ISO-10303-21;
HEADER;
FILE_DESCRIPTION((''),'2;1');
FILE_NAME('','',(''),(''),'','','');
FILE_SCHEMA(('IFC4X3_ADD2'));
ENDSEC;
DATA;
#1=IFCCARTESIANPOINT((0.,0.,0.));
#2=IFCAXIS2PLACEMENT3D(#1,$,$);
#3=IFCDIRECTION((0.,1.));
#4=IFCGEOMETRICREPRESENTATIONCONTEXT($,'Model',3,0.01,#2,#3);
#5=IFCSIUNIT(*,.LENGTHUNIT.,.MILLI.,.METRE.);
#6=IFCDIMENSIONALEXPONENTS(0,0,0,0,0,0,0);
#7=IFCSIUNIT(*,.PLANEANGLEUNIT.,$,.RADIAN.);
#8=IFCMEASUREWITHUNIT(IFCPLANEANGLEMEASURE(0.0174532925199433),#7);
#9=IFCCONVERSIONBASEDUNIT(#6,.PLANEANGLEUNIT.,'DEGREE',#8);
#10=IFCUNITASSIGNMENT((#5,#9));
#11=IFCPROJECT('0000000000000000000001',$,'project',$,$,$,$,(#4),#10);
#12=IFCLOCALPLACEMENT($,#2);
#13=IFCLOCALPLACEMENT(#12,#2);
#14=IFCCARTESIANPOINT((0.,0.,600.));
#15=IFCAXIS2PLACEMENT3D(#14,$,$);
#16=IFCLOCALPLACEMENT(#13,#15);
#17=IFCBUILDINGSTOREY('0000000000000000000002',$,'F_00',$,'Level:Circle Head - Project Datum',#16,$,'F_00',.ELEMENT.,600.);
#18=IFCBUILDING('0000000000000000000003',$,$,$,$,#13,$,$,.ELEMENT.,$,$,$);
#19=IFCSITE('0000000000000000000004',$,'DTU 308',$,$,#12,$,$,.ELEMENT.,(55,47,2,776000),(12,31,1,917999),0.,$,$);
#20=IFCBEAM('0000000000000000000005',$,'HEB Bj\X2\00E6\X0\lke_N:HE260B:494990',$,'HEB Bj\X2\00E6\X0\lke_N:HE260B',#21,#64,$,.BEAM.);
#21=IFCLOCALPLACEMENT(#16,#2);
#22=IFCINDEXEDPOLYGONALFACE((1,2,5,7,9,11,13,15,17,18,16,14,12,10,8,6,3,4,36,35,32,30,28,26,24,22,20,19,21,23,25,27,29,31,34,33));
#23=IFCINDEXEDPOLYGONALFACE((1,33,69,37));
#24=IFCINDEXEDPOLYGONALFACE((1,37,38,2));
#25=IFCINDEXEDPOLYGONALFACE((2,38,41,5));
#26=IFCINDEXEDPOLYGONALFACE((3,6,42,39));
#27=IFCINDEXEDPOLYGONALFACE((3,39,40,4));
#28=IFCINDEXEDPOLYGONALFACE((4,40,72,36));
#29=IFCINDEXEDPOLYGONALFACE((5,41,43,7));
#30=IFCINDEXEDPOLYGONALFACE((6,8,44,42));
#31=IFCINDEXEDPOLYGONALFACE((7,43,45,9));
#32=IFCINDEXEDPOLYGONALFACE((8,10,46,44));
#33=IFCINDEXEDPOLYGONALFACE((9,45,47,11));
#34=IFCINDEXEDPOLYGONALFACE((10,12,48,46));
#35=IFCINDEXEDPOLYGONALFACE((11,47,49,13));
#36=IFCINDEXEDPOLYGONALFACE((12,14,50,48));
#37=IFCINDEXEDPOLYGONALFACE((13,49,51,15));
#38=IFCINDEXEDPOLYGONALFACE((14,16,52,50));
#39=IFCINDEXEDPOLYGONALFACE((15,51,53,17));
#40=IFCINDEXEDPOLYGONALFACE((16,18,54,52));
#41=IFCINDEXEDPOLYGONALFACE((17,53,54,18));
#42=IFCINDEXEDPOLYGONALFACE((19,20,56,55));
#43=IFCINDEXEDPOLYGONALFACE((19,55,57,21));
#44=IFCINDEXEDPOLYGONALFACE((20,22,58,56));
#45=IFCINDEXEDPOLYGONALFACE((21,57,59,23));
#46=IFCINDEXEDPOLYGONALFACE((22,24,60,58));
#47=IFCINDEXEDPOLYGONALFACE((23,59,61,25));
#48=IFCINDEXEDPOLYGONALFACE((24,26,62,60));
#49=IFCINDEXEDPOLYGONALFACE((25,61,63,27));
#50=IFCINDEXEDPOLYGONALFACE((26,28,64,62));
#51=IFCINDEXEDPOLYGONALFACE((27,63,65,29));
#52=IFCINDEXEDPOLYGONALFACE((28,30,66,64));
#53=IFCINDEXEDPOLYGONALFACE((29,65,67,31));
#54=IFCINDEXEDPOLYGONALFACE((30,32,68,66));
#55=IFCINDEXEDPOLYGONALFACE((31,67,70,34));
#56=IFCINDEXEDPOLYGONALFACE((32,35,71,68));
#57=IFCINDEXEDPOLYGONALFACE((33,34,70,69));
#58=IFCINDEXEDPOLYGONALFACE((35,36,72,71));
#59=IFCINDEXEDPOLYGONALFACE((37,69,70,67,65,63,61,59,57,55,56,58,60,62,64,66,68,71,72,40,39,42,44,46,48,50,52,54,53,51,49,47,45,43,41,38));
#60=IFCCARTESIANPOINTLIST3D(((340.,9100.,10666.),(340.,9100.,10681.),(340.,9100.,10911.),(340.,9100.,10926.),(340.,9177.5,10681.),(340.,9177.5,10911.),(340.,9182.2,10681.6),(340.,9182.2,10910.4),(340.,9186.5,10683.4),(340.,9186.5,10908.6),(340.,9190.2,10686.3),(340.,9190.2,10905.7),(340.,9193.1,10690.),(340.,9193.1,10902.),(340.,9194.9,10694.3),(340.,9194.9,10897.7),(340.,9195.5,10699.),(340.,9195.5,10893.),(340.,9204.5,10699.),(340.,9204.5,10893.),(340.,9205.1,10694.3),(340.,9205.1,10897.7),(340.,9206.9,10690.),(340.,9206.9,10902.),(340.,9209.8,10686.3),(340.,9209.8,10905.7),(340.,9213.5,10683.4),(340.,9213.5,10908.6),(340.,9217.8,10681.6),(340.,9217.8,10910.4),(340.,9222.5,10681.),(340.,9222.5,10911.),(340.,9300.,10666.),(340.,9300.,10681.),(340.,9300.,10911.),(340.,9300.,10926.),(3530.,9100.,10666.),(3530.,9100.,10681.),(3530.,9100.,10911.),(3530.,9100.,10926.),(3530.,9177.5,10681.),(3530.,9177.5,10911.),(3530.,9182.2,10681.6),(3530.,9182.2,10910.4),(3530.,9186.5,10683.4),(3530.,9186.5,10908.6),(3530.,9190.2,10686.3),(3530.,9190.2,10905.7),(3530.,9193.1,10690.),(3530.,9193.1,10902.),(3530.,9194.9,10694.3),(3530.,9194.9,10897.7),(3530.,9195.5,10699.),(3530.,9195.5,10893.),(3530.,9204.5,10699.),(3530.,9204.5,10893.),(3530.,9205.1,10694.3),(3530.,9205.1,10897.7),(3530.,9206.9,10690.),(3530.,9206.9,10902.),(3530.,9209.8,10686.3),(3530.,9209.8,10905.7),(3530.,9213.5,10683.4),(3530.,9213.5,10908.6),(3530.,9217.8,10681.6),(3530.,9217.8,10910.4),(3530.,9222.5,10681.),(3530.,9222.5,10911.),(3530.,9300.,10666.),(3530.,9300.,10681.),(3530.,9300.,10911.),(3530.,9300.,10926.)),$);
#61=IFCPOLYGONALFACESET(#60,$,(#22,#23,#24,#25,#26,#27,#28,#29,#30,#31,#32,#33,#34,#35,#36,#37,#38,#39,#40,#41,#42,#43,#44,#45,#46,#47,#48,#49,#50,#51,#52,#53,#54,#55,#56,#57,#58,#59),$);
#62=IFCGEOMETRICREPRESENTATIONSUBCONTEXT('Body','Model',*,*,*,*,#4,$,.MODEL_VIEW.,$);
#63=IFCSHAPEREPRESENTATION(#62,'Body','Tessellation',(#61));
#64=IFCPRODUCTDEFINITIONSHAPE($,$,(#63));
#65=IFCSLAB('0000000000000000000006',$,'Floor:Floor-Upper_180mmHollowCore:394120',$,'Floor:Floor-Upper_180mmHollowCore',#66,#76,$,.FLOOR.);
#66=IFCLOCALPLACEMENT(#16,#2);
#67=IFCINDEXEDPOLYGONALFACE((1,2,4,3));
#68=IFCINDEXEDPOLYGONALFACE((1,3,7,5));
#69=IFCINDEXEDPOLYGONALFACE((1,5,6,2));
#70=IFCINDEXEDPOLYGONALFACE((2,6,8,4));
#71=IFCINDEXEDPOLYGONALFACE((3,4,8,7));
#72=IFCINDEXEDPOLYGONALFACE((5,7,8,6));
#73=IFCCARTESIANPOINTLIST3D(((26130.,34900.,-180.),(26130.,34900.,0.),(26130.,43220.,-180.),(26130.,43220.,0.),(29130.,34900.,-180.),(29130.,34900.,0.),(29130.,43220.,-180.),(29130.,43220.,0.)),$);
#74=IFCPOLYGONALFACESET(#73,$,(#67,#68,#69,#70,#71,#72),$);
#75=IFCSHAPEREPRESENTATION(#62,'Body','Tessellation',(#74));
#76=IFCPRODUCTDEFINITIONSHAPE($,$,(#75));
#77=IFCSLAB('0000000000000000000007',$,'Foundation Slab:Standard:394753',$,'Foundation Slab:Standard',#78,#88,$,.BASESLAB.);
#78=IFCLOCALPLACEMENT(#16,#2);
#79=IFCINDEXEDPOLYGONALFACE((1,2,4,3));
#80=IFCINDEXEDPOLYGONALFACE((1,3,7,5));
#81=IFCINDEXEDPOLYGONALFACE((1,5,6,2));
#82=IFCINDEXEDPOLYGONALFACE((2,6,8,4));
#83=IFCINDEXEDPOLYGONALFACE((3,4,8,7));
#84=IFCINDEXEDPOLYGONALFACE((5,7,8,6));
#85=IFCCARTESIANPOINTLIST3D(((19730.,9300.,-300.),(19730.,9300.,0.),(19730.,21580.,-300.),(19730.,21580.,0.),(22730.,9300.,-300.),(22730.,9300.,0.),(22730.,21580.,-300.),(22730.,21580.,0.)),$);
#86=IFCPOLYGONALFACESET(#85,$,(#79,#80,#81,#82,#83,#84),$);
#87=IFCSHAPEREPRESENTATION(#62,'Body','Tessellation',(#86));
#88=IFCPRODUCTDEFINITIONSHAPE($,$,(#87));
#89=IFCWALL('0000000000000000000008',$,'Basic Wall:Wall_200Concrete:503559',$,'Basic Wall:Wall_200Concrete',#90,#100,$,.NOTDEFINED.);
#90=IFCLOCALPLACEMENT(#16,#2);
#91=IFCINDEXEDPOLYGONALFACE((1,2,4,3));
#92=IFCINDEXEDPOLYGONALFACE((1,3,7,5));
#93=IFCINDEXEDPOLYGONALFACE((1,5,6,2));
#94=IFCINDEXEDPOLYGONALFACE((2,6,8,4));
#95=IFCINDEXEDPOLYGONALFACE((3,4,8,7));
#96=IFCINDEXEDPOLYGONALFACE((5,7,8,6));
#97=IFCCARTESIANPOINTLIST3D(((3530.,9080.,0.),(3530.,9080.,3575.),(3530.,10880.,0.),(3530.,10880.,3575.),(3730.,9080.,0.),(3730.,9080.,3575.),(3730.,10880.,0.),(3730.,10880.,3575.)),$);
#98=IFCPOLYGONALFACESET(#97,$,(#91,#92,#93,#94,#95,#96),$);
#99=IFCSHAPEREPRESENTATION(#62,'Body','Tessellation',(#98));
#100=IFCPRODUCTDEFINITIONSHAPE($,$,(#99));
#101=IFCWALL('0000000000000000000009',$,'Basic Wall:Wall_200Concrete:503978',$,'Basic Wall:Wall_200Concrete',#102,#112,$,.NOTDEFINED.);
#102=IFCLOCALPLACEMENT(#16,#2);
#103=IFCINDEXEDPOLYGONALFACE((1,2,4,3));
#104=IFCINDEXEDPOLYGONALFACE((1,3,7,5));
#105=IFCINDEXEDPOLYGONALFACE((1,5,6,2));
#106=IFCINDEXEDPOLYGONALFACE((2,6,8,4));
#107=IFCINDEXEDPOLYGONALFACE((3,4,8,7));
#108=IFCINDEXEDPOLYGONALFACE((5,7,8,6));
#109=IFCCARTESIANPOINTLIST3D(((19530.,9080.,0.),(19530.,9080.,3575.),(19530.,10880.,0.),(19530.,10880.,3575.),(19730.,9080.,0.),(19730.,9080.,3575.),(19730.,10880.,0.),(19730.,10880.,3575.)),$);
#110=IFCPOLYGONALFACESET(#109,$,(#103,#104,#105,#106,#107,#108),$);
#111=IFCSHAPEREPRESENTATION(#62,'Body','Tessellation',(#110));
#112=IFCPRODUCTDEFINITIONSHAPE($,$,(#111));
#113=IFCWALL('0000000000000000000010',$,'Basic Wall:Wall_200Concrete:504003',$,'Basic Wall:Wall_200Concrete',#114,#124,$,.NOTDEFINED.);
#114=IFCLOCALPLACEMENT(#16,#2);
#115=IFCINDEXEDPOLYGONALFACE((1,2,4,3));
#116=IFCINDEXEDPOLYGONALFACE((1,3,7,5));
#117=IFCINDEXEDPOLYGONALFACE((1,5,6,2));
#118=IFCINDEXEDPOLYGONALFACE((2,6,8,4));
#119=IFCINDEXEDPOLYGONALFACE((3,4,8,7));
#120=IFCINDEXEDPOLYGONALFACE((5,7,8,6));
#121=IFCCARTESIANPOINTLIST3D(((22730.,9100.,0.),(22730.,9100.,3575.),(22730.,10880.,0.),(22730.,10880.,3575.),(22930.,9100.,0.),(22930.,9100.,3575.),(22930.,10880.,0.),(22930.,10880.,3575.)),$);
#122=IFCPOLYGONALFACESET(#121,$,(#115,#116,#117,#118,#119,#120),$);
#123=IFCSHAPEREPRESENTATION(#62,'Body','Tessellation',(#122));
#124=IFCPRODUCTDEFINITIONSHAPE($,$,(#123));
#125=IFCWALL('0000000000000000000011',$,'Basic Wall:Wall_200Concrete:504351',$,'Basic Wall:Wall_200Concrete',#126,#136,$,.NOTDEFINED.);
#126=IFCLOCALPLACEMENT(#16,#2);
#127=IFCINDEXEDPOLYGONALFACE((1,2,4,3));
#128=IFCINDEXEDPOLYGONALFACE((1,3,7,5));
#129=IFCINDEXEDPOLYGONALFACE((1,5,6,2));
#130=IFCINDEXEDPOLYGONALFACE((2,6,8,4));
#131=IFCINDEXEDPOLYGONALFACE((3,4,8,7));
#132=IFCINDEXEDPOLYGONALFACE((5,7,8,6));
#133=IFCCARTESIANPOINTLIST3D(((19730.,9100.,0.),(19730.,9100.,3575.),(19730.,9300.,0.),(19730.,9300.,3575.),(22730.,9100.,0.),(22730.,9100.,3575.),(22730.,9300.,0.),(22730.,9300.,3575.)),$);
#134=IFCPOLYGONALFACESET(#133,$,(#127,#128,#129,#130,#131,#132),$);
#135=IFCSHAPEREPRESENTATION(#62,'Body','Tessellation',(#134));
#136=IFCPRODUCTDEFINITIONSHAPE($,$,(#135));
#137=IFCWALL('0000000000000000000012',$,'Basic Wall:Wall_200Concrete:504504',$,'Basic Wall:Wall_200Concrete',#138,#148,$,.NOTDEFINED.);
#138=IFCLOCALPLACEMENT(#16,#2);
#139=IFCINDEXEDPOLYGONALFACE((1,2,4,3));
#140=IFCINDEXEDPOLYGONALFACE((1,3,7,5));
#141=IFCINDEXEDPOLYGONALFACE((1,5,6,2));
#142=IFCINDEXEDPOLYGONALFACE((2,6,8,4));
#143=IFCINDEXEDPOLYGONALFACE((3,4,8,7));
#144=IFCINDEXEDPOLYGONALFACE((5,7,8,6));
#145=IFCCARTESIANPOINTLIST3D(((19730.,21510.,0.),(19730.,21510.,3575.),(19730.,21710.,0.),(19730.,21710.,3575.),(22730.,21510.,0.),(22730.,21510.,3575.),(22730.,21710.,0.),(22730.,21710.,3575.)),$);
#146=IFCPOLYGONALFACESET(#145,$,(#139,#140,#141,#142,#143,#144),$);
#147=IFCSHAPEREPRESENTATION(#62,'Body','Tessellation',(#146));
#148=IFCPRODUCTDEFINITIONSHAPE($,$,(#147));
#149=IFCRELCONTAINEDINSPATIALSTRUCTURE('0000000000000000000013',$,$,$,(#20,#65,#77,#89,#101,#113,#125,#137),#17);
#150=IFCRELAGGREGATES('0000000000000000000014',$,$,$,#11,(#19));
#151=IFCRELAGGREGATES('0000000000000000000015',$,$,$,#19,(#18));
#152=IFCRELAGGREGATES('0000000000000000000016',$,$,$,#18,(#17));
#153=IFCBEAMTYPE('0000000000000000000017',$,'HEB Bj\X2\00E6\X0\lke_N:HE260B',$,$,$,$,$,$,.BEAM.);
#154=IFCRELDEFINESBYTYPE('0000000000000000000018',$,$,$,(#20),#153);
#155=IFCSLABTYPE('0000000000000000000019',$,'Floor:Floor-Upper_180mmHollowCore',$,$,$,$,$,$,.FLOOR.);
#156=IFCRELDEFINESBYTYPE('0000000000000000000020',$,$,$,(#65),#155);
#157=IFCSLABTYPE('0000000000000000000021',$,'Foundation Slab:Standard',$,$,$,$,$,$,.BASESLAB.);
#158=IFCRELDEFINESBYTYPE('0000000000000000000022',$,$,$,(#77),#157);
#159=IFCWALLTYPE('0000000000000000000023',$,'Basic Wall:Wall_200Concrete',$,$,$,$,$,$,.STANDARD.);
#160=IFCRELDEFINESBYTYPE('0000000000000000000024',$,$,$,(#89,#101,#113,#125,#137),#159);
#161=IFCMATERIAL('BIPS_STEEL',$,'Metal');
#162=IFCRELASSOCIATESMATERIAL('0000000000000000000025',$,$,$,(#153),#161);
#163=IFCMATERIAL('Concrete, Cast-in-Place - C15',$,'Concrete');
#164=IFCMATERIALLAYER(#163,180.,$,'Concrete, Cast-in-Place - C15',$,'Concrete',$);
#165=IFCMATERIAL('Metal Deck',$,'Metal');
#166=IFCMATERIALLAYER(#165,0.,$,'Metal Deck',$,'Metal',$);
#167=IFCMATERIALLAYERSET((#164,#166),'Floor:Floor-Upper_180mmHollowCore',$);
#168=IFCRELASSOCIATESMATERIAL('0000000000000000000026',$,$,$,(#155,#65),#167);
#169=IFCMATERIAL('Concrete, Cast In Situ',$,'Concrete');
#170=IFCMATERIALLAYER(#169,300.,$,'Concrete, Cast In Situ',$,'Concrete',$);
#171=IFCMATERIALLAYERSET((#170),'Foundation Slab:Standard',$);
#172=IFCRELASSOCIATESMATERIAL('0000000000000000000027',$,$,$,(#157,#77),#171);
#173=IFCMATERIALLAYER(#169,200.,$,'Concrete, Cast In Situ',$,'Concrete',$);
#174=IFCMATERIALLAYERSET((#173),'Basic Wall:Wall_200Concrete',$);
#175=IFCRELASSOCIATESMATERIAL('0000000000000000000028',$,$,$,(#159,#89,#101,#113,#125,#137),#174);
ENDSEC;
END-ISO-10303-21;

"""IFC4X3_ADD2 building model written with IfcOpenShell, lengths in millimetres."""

from ifc_helpers import new_model, entity, si_unit, converted_unit, direction, frame, frame_2d, origin, place, context, subcontext, project, spatial, polyline, circle_curve, parameter, trimmed, segment, composite_curve, rectangle, i_section, outline, extrude, source, transform, mapped, material, layer, layer_set, layer_usage, material_profile, profile_set, type_object, element, save


model = new_model("IFC4X3_ADD2")

# Units and contexts
model_context = context("Model", 3, precision=0.01, world=origin(), true_north=direction((0.0, 1.0)))
body_context = subcontext(model_context, "Body", "Model", "MODEL_VIEW")
ifc_project = project(units=[si_unit("LENGTHUNIT", "METRE", prefix="MILLI"), converted_unit("PLANEANGLEUNIT", "DEGREE", entity("IfcPlaneAngleMeasure", 0.0174532925199433), si_unit("PLANEANGLEUNIT", "RADIAN"), dimensions=[0, 0, 0, 0, 0, 0, 0])], contexts=[model_context])

# Site, building, storey
site_placement = place(None, origin())
site = spatial("IfcSite", under=ifc_project, at=site_placement, Name="DTU 308", CompositionType="ELEMENT", RefLatitude=(55, 47, 2, 776000), RefLongitude=(12, 31, 1, 917999), RefElevation=0.0)
building_placement = place(site_placement, origin())
building = spatial("IfcBuilding", under=site, at=building_placement, CompositionType="ELEMENT")
storey_placement = place(building_placement, frame((0.0, 0.0, 600.0)))
storey = spatial("IfcBuildingStorey", under=building, at=storey_placement, Name="F_00", ObjectType="Level:Circle Head - Project Datum", LongName="F_00", CompositionType="ELEMENT", Elevation=600.0)

# Shared definitions
ifc_material_1 = material(Name="BIPS_STEEL", Category="Metal")

# Beam
ifc_material_profile_1 = material_profile(ifc_material_1, i_section(OverallWidth=200.0, OverallDepth=260.0, WebThickness=9.0, FlangeThickness=15.0, FilletRadius=18.0, at=frame_2d((0.0, 0.0), x_axis=(1.0, 0.0))), Name="HE260B")
ifc_profile_set_1 = profile_set([ifc_material_profile_1], Name="HE260B")
beam_type = type_object("IfcBeamType", Name="HEB Bjælke_N:HE260B", PredefinedType="BEAM", material=ifc_profile_set_1)
shared_shape_1 = source(origin(), body_context, "Body", "SweptSolid", [
    extrude(outline(composite_curve([segment(polyline([(-100.0, -115.0), (-100.0, -130.0)]), True, "CONTINUOUS"), segment(polyline([(-100.0, -130.0), (100.0, -130.0)]), True, "CONTINUOUS"), segment(polyline([(100.0, -130.0), (100.0, -115.0)]), True, "CONTINUOUS"), segment(polyline([(100.0, -115.0), (22.5, -115.0)]), True, "CONTINUOUS"), segment(trimmed(circle_curve(frame_2d((22.5, -97.0), x_axis=(1.0, 0.0)), 18.0), [parameter(180.0)], [parameter(270.0)], True, "PARAMETER"), False, "CONTINUOUS"), segment(polyline([(4.5, -97.0), (4.5, 97.0)]), True, "CONTINUOUS"), segment(trimmed(circle_curve(frame_2d((22.5, 97.0), x_axis=(1.0, 0.0)), 18.0), [parameter(90.0)], [parameter(180.0)], True, "PARAMETER"), False, "CONTINUOUS"), segment(polyline([(22.5, 115.0), (100.0, 115.0)]), True, "CONTINUOUS"), segment(polyline([(100.0, 115.0), (100.0, 130.0)]), True, "CONTINUOUS"), segment(polyline([(100.0, 130.0), (-100.0, 130.0)]), True, "CONTINUOUS"), segment(polyline([(-100.0, 130.0), (-100.0, 115.0)]), True, "CONTINUOUS"), segment(polyline([(-100.0, 115.0), (-22.5, 115.0)]), True, "CONTINUOUS"), segment(trimmed(circle_curve(frame_2d((-22.5, 97.0), x_axis=(1.0, 0.0)), 18.0), [parameter(360.0)], [parameter(90.0)], True, "PARAMETER"), False, "CONTINUOUS"), segment(polyline([(-4.5, 97.0), (-4.5, -97.0)]), True, "CONTINUOUS"), segment(trimmed(circle_curve(frame_2d((-22.5, -97.0), x_axis=(1.0, 0.0)), 18.0), [parameter(270.0)], [parameter(360.0)], True, "PARAMETER"), False, "CONTINUOUS"), segment(polyline([(-22.5, -115.0), (-100.0, -115.0)]), True, "CONTINUOUS")], self_intersect=False)), frame((-40.0, 0.0, 0.0), z_axis=(-1.0, 0.0, 0.0), x_axis=(0.0, -1.0, 0.0)), (0.0, 0.0, -1.0), 3190.0),
])
for number, where, name in (
    (1, (380.0, 9200.0, 10796.0), "HEB Bjælke_N:HE260B:494990"),
):
    element("IfcBeam", number, at=place(storey_placement, frame(where)), inside=storey, type_object=beam_type, Name=name, ObjectType="HEB Bjælke_N:HE260B", PredefinedType="BEAM", context=body_context, shape_type="MappedRepresentation", body=[
        mapped(shared_shape_1, transform((0.0, 0.0, 0.0), scale=1.0)),
    ])

# Slabs
ifc_material_2 = material(Name="Concrete, Cast-in-Place - C15", Category="Concrete")
ifc_layer_1 = layer(ifc_material_2, 180.0, Name="Concrete, Cast-in-Place - C15", Category="Concrete")
ifc_material_3 = material(Name="Metal Deck", Category="Metal")
ifc_layer_2 = layer(ifc_material_3, 0.0, Name="Metal Deck", Category="Metal")
ifc_layer_set_1 = layer_set([ifc_layer_1, ifc_layer_2], Name="Floor:Floor-Upper_180mmHollowCore")
ifc_layer_usage_1 = layer_usage(ifc_layer_set_1, "AXIS3", "POSITIVE", 0.0)
slab_type_1 = type_object("IfcSlabType", Name="Floor:Floor-Upper_180mmHollowCore", PredefinedType="FLOOR", material=ifc_layer_set_1)
slab_1_placement = place(storey_placement, frame((26130.0, 34900.0, -180.0)))
element("IfcSlab", 2, at=slab_1_placement, inside=storey, type_object=slab_type_1, material=ifc_layer_usage_1, Name="Floor:Floor-Upper_180mmHollowCore:394120", ObjectType="Floor:Floor-Upper_180mmHollowCore", PredefinedType="FLOOR", context=body_context, shape_type="SweptSolid", body=[
    extrude(rectangle(XDim=8320.0, YDim=3000.0, at=frame_2d((4800.0, 0.0), x_axis=(0.0, -1.0))), frame((6300.0, 4160.0, 180.0), z_axis=(0.0, 0.0, -1.0), x_axis=(-1.0, 0.0, 0.0)), (0.0, 0.0, 1.0), 180.0),
])
ifc_material_4 = material(Name="Concrete, Cast In Situ", Category="Concrete")
ifc_layer_3 = layer(ifc_material_4, 300.0, Name="Concrete, Cast In Situ", Category="Concrete")
ifc_layer_set_2 = layer_set([ifc_layer_3], Name="Foundation Slab:Standard")
ifc_layer_usage_2 = layer_usage(ifc_layer_set_2, "AXIS3", "POSITIVE", 0.0)
slab_type_2 = type_object("IfcSlabType", Name="Foundation Slab:Standard", PredefinedType="BASESLAB", material=ifc_layer_set_2)
slab_2_placement = place(storey_placement, frame((19730.0, 9300.0, -300.0)))
element("IfcSlab", 3, at=slab_2_placement, inside=storey, type_object=slab_type_2, material=ifc_layer_usage_2, Name="Foundation Slab:Standard:394753", ObjectType="Foundation Slab:Standard", PredefinedType="BASESLAB", context=body_context, shape_type="SweptSolid", body=[
    extrude(rectangle(XDim=12280.0, YDim=3000.0, at=frame_2d((16000.0, 0.0), x_axis=(0.0, -1.0))), frame((17500.0, 6140.0, 300.0), z_axis=(0.0, 0.0, -1.0), x_axis=(-1.0, 0.0, 0.0)), (0.0, 0.0, 1.0), 300.0),
])

# Walls
ifc_layer_4 = layer(ifc_material_4, 200.0, Name="Concrete, Cast In Situ", Category="Concrete")
ifc_layer_set_3 = layer_set([ifc_layer_4], Name="Basic Wall:Wall_200Concrete")
wall_type = type_object("IfcWallType", Name="Basic Wall:Wall_200Concrete", PredefinedType="STANDARD", material=ifc_layer_set_3)
wall_1_placement = place(storey_placement, frame((3630.0, 10880.0, 0.0), z_axis=(0.0, 0.0, 1.0), x_axis=(0.0, -1.0, 0.0)))
element("IfcWall", 4, at=wall_1_placement, inside=storey, type_object=wall_type, material=ifc_layer_set_3, Name="Basic Wall:Wall_200Concrete:503559", ObjectType="Basic Wall:Wall_200Concrete", PredefinedType="NOTDEFINED", context=body_context, shape_type="SweptSolid", body=[
    extrude(rectangle(XDim=1800.0, YDim=200.0, at=frame_2d((900.0, 0.0), x_axis=(-1.0, 0.0))), origin(), (0.0, 0.0, 1.0), 3575.0),
])
wall_2_placement = place(storey_placement, frame((19630.0, 10880.0, 0.0), z_axis=(0.0, 0.0, 1.0), x_axis=(0.0, -1.0, 0.0)))
element("IfcWall", 5, at=wall_2_placement, inside=storey, type_object=wall_type, material=ifc_layer_set_3, Name="Basic Wall:Wall_200Concrete:503978", ObjectType="Basic Wall:Wall_200Concrete", PredefinedType="NOTDEFINED", context=body_context, shape_type="SweptSolid", body=[
    extrude(rectangle(XDim=1800.0, YDim=200.0, at=frame_2d((900.0, 0.0), x_axis=(-1.0, 0.0))), origin(), (0.0, 0.0, 1.0), 3575.0),
])
wall_3_placement = place(storey_placement, frame((22830.0, 10880.0, 0.0), z_axis=(0.0, 0.0, 1.0), x_axis=(0.0, -1.0, 0.0)))
element("IfcWall", 6, at=wall_3_placement, inside=storey, type_object=wall_type, material=ifc_layer_set_3, Name="Basic Wall:Wall_200Concrete:504003", ObjectType="Basic Wall:Wall_200Concrete", PredefinedType="NOTDEFINED", context=body_context, shape_type="SweptSolid", body=[
    extrude(rectangle(XDim=1780.0, YDim=200.0, at=frame_2d((890.0, 0.0), x_axis=(-1.0, 0.0))), origin(), (0.0, 0.0, 1.0), 3575.0),
])
wall_4_placement = place(storey_placement, frame((22730.0, 9200.0, 0.0), z_axis=(0.0, 0.0, 1.0), x_axis=(-1.0, 0.0, 0.0)))
element("IfcWall", 7, at=wall_4_placement, inside=storey, type_object=wall_type, material=ifc_layer_set_3, Name="Basic Wall:Wall_200Concrete:504351", ObjectType="Basic Wall:Wall_200Concrete", PredefinedType="NOTDEFINED", context=body_context, shape_type="SweptSolid", body=[
    extrude(rectangle(XDim=3000.0, YDim=200.0, at=frame_2d((1500.0, 0.0), x_axis=(-1.0, 0.0))), origin(), (0.0, 0.0, 1.0), 3575.0),
])
wall_5_placement = place(storey_placement, frame((22730.0, 21610.0, 0.0), z_axis=(0.0, 0.0, 1.0), x_axis=(-1.0, 0.0, 0.0)))
element("IfcWall", 8, at=wall_5_placement, inside=storey, type_object=wall_type, material=ifc_layer_set_3, Name="Basic Wall:Wall_200Concrete:504504", ObjectType="Basic Wall:Wall_200Concrete", PredefinedType="NOTDEFINED", context=body_context, shape_type="SweptSolid", body=[
    extrude(rectangle(XDim=3000.0, YDim=200.0, at=frame_2d((1500.0, 0.0), x_axis=(-1.0, 0.0))), origin(), (0.0, 0.0, 1.0), 3575.0),
])

save(model, "model.ifc")
